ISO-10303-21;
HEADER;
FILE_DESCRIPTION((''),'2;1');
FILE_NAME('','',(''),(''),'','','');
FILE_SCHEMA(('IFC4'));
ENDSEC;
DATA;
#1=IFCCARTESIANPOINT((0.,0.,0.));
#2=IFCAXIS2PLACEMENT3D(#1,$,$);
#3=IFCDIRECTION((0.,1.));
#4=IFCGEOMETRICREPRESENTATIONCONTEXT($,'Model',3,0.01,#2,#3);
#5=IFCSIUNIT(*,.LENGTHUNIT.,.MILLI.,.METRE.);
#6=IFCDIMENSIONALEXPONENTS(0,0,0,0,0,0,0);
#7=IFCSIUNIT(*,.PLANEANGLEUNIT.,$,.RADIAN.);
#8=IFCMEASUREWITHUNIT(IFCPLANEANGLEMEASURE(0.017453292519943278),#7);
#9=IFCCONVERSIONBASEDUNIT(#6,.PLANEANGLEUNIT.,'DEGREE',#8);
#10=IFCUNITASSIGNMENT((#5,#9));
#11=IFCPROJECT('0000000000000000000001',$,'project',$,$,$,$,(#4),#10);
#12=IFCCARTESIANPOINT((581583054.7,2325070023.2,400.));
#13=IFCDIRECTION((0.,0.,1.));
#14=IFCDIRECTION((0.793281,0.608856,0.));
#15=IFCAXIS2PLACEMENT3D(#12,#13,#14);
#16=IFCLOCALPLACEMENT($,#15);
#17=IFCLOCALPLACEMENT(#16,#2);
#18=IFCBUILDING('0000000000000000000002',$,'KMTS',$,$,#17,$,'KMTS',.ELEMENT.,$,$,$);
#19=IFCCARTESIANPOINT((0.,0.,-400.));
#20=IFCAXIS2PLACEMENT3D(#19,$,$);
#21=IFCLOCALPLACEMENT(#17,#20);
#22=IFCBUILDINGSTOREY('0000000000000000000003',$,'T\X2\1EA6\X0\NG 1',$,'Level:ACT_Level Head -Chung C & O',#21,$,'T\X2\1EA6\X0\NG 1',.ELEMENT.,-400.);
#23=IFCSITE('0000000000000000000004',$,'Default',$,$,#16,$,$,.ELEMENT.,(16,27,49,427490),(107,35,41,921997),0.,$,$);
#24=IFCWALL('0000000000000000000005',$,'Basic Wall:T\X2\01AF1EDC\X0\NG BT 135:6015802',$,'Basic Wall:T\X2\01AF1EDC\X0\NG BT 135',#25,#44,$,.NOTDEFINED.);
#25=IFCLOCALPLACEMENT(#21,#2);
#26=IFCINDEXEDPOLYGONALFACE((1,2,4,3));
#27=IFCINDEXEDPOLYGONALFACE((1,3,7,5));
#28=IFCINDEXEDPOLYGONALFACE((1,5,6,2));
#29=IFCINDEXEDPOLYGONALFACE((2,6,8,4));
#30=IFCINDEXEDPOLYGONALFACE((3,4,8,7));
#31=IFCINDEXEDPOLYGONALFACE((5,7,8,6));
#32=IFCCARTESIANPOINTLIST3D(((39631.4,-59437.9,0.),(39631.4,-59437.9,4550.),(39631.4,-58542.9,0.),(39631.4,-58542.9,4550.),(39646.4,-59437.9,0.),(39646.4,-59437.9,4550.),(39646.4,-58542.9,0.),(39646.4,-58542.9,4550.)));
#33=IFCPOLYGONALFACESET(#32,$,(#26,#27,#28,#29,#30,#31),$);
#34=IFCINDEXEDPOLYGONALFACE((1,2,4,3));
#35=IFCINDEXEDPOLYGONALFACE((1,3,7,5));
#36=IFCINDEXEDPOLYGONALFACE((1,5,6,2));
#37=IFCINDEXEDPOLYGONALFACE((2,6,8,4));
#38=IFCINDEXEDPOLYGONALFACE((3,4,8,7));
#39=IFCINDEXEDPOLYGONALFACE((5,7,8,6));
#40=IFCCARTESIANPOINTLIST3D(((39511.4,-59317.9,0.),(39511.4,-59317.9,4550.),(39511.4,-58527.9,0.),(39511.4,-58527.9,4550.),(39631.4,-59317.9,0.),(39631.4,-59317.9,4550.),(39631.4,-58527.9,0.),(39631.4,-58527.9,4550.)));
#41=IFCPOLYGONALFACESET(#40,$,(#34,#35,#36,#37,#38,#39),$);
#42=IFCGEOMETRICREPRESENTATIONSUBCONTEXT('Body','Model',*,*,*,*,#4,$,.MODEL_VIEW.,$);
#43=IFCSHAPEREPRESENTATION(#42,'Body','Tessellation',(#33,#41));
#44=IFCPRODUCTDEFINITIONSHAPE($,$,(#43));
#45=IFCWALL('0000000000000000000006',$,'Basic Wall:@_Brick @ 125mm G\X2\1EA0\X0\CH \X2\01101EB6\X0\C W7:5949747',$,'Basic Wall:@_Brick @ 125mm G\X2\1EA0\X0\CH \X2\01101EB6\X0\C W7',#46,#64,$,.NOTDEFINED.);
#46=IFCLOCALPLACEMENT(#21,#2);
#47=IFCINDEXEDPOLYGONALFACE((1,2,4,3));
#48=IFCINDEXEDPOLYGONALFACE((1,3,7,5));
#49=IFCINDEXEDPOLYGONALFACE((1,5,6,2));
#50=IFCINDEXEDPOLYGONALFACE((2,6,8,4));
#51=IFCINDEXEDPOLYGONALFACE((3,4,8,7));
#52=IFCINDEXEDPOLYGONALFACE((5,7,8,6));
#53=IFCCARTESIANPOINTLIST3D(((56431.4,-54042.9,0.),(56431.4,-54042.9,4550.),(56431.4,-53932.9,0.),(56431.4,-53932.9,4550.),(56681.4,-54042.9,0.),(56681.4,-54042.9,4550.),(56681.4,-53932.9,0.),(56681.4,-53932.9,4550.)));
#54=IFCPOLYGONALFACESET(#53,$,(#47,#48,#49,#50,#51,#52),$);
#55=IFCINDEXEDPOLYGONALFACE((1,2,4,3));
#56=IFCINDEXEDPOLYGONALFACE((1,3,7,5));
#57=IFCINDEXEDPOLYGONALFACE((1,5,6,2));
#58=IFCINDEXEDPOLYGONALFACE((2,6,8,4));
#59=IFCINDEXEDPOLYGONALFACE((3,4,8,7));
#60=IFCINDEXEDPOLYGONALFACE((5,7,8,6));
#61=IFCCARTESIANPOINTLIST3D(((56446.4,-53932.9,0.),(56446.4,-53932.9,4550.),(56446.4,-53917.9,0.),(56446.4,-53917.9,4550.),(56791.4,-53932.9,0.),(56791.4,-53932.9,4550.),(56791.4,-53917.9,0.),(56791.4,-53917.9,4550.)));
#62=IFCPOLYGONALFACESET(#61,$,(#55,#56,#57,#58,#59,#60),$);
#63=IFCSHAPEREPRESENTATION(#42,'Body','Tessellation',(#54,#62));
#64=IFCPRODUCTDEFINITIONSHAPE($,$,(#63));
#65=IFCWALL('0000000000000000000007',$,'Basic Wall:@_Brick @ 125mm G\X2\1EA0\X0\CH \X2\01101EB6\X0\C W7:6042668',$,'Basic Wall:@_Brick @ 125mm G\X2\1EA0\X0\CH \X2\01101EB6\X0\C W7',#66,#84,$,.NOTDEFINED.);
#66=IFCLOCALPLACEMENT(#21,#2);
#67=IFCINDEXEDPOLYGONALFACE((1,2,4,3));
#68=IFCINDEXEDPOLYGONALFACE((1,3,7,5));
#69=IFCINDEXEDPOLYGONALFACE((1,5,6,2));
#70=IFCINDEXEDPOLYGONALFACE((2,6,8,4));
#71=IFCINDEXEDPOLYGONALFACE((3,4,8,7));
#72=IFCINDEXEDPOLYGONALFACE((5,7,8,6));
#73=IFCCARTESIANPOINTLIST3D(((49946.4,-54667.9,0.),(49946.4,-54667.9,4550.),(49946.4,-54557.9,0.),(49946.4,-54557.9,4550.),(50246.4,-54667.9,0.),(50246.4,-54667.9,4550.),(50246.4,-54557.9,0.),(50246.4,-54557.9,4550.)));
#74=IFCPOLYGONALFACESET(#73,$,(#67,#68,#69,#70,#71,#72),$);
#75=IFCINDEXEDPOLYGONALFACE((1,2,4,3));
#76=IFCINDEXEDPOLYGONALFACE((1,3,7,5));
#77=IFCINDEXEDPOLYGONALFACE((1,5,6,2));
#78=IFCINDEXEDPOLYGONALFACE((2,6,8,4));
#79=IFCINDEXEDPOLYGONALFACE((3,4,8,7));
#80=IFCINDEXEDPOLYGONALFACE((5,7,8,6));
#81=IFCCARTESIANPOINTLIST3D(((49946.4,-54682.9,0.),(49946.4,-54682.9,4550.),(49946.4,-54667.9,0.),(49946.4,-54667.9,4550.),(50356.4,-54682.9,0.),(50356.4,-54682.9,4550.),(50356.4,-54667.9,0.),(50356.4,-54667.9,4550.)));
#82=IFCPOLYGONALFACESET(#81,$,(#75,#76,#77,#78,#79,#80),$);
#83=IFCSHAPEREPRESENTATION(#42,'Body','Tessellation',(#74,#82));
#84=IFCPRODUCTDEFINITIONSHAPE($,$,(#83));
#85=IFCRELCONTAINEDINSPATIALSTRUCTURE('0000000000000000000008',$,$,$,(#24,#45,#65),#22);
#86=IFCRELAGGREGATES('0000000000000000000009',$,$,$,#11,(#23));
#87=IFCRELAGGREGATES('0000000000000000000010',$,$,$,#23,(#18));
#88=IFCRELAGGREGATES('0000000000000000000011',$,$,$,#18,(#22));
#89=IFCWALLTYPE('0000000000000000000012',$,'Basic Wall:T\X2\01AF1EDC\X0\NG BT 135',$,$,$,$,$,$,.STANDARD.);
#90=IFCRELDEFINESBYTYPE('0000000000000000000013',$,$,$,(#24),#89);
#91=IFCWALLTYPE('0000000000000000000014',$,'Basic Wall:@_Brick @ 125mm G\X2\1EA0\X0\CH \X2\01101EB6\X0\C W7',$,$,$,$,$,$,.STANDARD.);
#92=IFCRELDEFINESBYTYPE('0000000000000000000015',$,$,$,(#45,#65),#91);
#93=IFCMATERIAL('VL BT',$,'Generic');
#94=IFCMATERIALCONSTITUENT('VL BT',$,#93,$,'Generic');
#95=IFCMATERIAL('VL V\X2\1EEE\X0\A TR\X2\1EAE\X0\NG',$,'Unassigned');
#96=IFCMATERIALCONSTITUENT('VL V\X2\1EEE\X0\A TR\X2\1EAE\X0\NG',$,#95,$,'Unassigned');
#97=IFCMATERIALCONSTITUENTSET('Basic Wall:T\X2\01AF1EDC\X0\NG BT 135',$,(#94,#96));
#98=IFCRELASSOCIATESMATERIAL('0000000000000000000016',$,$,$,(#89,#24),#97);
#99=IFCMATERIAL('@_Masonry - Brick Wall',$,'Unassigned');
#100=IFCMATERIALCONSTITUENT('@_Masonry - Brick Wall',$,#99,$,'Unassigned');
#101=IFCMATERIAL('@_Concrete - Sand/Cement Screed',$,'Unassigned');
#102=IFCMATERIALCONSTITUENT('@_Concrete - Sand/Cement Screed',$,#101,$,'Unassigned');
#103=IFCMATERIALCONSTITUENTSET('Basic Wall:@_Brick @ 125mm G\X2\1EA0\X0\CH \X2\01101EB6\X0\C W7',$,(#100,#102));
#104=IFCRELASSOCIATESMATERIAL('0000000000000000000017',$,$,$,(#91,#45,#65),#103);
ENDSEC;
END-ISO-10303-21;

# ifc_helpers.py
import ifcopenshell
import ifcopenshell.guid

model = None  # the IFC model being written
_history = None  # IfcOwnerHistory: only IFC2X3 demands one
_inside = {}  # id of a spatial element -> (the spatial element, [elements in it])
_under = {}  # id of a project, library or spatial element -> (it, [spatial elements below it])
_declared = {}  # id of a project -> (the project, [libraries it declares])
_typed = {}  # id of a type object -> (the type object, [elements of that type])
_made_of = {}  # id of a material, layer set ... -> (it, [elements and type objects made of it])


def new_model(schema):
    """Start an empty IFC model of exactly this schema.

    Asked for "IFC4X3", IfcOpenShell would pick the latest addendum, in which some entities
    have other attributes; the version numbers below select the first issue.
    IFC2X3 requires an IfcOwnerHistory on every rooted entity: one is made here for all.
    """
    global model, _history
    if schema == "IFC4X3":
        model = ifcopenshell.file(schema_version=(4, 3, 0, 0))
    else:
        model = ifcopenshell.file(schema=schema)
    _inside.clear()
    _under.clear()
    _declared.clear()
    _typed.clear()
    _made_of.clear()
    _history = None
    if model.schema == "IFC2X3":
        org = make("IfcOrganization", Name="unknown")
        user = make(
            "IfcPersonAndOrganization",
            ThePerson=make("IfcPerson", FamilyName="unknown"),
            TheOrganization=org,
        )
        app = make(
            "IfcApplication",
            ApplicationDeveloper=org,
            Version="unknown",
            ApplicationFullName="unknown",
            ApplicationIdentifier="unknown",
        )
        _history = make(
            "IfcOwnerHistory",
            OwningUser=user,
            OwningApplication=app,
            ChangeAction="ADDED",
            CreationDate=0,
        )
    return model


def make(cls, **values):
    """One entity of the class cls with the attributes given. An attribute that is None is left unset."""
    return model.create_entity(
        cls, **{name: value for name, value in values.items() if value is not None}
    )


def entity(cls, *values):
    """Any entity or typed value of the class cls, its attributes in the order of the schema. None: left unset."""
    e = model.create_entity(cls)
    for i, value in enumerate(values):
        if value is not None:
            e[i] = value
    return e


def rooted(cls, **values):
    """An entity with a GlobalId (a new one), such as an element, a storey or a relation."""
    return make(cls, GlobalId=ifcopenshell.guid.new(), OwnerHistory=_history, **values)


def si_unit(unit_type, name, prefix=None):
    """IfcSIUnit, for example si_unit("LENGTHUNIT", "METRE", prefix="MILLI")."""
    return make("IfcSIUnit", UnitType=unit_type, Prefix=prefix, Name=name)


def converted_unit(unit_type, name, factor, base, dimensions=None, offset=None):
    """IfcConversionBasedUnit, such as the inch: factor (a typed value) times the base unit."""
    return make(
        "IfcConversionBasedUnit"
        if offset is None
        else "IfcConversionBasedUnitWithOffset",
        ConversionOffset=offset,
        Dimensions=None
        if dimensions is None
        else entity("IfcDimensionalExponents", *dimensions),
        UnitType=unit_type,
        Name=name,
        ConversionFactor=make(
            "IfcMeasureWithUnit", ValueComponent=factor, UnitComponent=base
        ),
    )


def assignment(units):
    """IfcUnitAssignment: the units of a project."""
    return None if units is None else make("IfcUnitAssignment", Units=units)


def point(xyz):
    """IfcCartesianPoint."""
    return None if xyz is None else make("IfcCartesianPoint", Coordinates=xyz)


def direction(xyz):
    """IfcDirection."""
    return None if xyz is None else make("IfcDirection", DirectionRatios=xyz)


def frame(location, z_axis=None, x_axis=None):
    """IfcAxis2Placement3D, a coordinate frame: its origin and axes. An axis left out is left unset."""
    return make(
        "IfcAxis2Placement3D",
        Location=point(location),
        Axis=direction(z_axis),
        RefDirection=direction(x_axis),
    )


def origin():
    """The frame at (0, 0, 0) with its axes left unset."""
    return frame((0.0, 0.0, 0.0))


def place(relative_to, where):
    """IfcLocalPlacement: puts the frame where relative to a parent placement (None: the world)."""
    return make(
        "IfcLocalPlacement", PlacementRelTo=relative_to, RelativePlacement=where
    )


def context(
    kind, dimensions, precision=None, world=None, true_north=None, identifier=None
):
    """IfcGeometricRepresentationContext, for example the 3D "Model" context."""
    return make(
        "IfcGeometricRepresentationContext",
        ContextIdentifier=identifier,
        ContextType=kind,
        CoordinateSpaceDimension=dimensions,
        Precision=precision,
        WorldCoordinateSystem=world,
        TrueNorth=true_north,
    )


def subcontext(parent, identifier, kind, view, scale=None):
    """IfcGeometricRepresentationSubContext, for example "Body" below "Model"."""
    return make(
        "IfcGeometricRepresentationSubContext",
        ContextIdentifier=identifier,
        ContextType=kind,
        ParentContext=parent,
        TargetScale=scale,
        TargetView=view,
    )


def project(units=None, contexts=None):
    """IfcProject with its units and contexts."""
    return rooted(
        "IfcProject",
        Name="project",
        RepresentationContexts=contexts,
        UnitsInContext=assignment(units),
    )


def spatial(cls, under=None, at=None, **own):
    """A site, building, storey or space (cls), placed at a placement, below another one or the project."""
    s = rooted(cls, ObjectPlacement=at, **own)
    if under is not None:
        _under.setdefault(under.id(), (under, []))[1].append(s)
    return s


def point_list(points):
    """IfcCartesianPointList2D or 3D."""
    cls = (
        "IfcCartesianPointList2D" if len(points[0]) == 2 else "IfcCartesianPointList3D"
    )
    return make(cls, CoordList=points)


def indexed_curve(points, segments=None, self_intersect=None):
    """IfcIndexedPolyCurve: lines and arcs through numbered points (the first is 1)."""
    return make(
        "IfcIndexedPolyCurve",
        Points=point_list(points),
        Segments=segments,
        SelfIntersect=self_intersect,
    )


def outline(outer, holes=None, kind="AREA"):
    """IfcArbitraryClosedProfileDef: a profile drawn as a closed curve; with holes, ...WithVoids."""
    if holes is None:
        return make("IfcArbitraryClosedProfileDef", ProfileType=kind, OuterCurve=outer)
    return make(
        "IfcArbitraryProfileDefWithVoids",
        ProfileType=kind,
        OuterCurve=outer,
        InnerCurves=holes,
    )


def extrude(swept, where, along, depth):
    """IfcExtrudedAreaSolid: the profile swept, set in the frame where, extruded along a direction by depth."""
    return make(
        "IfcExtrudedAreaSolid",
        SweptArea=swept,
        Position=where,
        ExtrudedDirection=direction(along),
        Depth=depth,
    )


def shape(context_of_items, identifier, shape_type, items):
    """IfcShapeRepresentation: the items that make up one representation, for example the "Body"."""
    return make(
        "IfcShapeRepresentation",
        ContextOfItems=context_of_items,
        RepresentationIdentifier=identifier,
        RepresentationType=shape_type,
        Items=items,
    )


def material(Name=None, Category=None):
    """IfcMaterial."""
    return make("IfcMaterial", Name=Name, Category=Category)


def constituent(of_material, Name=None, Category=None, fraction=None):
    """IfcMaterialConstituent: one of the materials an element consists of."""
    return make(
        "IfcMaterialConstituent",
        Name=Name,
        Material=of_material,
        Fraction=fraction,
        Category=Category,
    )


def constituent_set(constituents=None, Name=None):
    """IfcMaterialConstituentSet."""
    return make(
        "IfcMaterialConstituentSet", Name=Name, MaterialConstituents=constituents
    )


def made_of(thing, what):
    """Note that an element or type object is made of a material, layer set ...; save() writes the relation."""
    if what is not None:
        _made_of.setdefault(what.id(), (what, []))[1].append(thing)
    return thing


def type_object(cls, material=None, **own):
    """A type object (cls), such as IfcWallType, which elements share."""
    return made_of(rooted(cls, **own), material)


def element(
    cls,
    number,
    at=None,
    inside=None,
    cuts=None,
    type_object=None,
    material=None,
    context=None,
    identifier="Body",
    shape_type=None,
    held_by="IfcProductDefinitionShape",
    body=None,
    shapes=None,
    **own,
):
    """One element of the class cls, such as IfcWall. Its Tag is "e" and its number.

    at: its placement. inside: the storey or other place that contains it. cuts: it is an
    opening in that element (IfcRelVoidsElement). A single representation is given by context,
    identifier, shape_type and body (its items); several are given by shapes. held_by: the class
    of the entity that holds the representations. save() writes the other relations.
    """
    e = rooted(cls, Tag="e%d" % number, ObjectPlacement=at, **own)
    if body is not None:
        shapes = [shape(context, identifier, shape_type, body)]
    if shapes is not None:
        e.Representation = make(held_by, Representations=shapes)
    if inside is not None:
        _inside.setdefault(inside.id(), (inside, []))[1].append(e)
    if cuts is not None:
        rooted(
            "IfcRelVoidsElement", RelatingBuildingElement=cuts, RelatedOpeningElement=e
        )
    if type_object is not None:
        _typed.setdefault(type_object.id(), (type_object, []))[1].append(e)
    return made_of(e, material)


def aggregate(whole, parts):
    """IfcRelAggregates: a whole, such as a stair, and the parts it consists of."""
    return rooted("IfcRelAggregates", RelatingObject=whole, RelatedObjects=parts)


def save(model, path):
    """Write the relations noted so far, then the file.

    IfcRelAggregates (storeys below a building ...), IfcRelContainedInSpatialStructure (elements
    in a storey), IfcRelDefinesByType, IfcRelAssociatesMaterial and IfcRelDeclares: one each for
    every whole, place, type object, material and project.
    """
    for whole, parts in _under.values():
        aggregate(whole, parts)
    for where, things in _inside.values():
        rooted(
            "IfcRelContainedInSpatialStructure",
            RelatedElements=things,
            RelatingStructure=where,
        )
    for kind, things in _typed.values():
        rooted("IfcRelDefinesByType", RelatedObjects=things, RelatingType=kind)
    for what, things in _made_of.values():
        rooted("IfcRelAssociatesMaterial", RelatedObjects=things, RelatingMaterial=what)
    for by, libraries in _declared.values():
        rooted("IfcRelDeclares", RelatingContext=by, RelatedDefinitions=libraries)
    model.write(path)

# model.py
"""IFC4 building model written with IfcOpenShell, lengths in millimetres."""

from ifc_helpers import new_model, entity, si_unit, converted_unit, direction, frame, origin, place, context, subcontext, project, spatial, indexed_curve, outline, extrude, material, constituent, constituent_set, type_object, element, save


model = new_model("IFC4")

# Units and contexts
model_context = context("Model", 3, precision=0.01, world=origin(), true_north=direction((0.0, 1.0)))
body_context = subcontext(model_context, "Body", "Model", "MODEL_VIEW")
ifc_project = project(units=[si_unit("LENGTHUNIT", "METRE", prefix="MILLI"), converted_unit("PLANEANGLEUNIT", "DEGREE", entity("IfcPlaneAngleMeasure", 0.017453292519943278), si_unit("PLANEANGLEUNIT", "RADIAN"), dimensions=[0, 0, 0, 0, 0, 0, 0])], contexts=[model_context])

# Site, building, storey
site_placement = place(None, frame((581583054.7, 2325070023.2, 400.0), z_axis=(0.0, 0.0, 1.0), x_axis=(0.793281, 0.608856, 0.0)))
site = spatial("IfcSite", under=ifc_project, at=site_placement, Name="Default", CompositionType="ELEMENT", RefLatitude=(16, 27, 49, 427490), RefLongitude=(107, 35, 41, 921997), RefElevation=0.0)
building_placement = place(site_placement, origin())
building = spatial("IfcBuilding", under=site, at=building_placement, Name="KMTS", LongName="KMTS", CompositionType="ELEMENT")
storey_placement = place(building_placement, frame((0.0, 0.0, -400.0)))
storey = spatial("IfcBuildingStorey", under=building, at=storey_placement, Name="TẦNG 1", ObjectType="Level:ACT_Level Head -Chung C & O", LongName="TẦNG 1", CompositionType="ELEMENT", Elevation=-400.0)

# Shared definitions
ifc_material_1 = material(Name="VL VỮA TRẮNG", Category="Unassigned")
ifc_material_2 = material(Name="VL BT", Category="Generic")

# Walls
ifc_constituent_1 = constituent(ifc_material_2, Name="VL BT", Category="Generic")
ifc_constituent_2 = constituent(ifc_material_1, Name="VL VỮA TRẮNG", Category="Unassigned")
ifc_constituent_set_1 = constituent_set(constituents=[ifc_constituent_1, ifc_constituent_2], Name="Basic Wall:TƯỜNG BT 135")
wall_type_1 = type_object("IfcWallType", Name="Basic Wall:TƯỜNG BT 135", PredefinedType="STANDARD", material=ifc_constituent_set_1)
wall_1_placement = place(storey_placement, frame((39578.9, -59317.9, 0.0), z_axis=(0.0, 0.0, 1.0), x_axis=(0.0, 1.0, 0.0)))
element("IfcWall", 1, at=wall_1_placement, inside=storey, type_object=wall_type_1, material=ifc_constituent_set_1, Name="Basic Wall:TƯỜNG BT 135:6015802", ObjectType="Basic Wall:TƯỜNG BT 135", PredefinedType="NOTDEFINED", context=body_context, shape_type="SweptSolid", body=[
    extrude(outline(indexed_curve([(-7.5, -447.5), (7.5, -447.5), (7.5, 447.5), (-7.5, 447.5), (-7.5, -447.5)], self_intersect=False)), frame((327.5, -60.0, 0.0), z_axis=(0.0, 0.0, 1.0), x_axis=(0.0, 1.0, 0.0)), (0.0, 0.0, 1.0), 4550.0),
    extrude(outline(indexed_curve([(-60.0, -395.0), (60.0, -395.0), (60.0, 395.0), (-60.0, 395.0), (-60.0, -395.0)], self_intersect=False)), frame((395.0, 7.5, 0.0), z_axis=(0.0, 0.0, 1.0), x_axis=(0.0, -1.0, 0.0)), (0.0, 0.0, 1.0), 4550.0),
])
ifc_material_3 = material(Name="@_Masonry - Brick Wall", Category="Unassigned")
ifc_constituent_3 = constituent(ifc_material_3, Name="@_Masonry - Brick Wall", Category="Unassigned")
ifc_material_4 = material(Name="@_Concrete - Sand/Cement Screed", Category="Unassigned")
ifc_constituent_4 = constituent(ifc_material_4, Name="@_Concrete - Sand/Cement Screed", Category="Unassigned")
ifc_constituent_set_2 = constituent_set(constituents=[ifc_constituent_3, ifc_constituent_4], Name="Basic Wall:@_Brick @ 125mm GẠCH ĐẶC W7")
wall_type_2 = type_object("IfcWallType", Name="Basic Wall:@_Brick @ 125mm GẠCH ĐẶC W7", PredefinedType="STANDARD", material=ifc_constituent_set_2)
wall_2_placement = place(storey_placement, frame((56681.4, -53980.4, 0.0), z_axis=(0.0, 0.0, 1.0), x_axis=(-1.0, 0.0, 0.0)))
element("IfcWall", 2, at=wall_2_placement, inside=storey, type_object=wall_type_2, material=ifc_constituent_set_2, Name="Basic Wall:@_Brick @ 125mm GẠCH ĐẶC W7:5949747", ObjectType="Basic Wall:@_Brick @ 125mm GẠCH ĐẶC W7", PredefinedType="NOTDEFINED", context=body_context, shape_type="SweptSolid", body=[
    extrude(outline(indexed_curve([(-55.0, -125.0), (55.0, -125.0), (55.0, 125.0), (-55.0, 125.0), (-55.0, -125.0)], self_intersect=False)), frame((125.0, 7.5, 0.0), z_axis=(0.0, 0.0, 1.0), x_axis=(0.0, -1.0, 0.0)), (0.0, 0.0, 1.0), 4550.0),
    extrude(outline(indexed_curve([(-7.5, -172.5), (7.5, -172.5), (7.5, 172.5), (-7.5, 172.5), (-7.5, -172.5)], self_intersect=False)), frame((62.5, -55.0, 0.0), z_axis=(0.0, 0.0, 1.0), x_axis=(0.0, 1.0, 0.0)), (0.0, 0.0, 1.0), 4550.0),
])
wall_3_placement = place(storey_placement, frame((50246.4, -54620.4, 0.0), z_axis=(0.0, 0.0, 1.0), x_axis=(-1.0, 0.0, 0.0)))
element("IfcWall", 3, at=wall_3_placement, inside=storey, type_object=wall_type_2, material=ifc_constituent_set_2, Name="Basic Wall:@_Brick @ 125mm GẠCH ĐẶC W7:6042668", ObjectType="Basic Wall:@_Brick @ 125mm GẠCH ĐẶC W7", PredefinedType="NOTDEFINED", context=body_context, shape_type="SweptSolid", body=[
    extrude(outline(indexed_curve([(-55.0, -150.0), (55.0, -150.0), (55.0, 150.0), (-55.0, 150.0), (-55.0, -150.0)], self_intersect=False)), frame((150.0, -7.5, 0.0), z_axis=(0.0, 0.0, 1.0), x_axis=(0.0, 1.0, 0.0)), (0.0, 0.0, 1.0), 4550.0),
    extrude(outline(indexed_curve([(-7.5, -205.0), (7.5, -205.0), (7.5, 205.0), (-7.5, 205.0), (-7.5, -205.0)], self_intersect=False)), frame((95.0, 55.0, 0.0), z_axis=(0.0, 0.0, 1.0), x_axis=(0.0, -1.0, 0.0)), (0.0, 0.0, 1.0), 4550.0),
])

save(model, "model.ifc")
